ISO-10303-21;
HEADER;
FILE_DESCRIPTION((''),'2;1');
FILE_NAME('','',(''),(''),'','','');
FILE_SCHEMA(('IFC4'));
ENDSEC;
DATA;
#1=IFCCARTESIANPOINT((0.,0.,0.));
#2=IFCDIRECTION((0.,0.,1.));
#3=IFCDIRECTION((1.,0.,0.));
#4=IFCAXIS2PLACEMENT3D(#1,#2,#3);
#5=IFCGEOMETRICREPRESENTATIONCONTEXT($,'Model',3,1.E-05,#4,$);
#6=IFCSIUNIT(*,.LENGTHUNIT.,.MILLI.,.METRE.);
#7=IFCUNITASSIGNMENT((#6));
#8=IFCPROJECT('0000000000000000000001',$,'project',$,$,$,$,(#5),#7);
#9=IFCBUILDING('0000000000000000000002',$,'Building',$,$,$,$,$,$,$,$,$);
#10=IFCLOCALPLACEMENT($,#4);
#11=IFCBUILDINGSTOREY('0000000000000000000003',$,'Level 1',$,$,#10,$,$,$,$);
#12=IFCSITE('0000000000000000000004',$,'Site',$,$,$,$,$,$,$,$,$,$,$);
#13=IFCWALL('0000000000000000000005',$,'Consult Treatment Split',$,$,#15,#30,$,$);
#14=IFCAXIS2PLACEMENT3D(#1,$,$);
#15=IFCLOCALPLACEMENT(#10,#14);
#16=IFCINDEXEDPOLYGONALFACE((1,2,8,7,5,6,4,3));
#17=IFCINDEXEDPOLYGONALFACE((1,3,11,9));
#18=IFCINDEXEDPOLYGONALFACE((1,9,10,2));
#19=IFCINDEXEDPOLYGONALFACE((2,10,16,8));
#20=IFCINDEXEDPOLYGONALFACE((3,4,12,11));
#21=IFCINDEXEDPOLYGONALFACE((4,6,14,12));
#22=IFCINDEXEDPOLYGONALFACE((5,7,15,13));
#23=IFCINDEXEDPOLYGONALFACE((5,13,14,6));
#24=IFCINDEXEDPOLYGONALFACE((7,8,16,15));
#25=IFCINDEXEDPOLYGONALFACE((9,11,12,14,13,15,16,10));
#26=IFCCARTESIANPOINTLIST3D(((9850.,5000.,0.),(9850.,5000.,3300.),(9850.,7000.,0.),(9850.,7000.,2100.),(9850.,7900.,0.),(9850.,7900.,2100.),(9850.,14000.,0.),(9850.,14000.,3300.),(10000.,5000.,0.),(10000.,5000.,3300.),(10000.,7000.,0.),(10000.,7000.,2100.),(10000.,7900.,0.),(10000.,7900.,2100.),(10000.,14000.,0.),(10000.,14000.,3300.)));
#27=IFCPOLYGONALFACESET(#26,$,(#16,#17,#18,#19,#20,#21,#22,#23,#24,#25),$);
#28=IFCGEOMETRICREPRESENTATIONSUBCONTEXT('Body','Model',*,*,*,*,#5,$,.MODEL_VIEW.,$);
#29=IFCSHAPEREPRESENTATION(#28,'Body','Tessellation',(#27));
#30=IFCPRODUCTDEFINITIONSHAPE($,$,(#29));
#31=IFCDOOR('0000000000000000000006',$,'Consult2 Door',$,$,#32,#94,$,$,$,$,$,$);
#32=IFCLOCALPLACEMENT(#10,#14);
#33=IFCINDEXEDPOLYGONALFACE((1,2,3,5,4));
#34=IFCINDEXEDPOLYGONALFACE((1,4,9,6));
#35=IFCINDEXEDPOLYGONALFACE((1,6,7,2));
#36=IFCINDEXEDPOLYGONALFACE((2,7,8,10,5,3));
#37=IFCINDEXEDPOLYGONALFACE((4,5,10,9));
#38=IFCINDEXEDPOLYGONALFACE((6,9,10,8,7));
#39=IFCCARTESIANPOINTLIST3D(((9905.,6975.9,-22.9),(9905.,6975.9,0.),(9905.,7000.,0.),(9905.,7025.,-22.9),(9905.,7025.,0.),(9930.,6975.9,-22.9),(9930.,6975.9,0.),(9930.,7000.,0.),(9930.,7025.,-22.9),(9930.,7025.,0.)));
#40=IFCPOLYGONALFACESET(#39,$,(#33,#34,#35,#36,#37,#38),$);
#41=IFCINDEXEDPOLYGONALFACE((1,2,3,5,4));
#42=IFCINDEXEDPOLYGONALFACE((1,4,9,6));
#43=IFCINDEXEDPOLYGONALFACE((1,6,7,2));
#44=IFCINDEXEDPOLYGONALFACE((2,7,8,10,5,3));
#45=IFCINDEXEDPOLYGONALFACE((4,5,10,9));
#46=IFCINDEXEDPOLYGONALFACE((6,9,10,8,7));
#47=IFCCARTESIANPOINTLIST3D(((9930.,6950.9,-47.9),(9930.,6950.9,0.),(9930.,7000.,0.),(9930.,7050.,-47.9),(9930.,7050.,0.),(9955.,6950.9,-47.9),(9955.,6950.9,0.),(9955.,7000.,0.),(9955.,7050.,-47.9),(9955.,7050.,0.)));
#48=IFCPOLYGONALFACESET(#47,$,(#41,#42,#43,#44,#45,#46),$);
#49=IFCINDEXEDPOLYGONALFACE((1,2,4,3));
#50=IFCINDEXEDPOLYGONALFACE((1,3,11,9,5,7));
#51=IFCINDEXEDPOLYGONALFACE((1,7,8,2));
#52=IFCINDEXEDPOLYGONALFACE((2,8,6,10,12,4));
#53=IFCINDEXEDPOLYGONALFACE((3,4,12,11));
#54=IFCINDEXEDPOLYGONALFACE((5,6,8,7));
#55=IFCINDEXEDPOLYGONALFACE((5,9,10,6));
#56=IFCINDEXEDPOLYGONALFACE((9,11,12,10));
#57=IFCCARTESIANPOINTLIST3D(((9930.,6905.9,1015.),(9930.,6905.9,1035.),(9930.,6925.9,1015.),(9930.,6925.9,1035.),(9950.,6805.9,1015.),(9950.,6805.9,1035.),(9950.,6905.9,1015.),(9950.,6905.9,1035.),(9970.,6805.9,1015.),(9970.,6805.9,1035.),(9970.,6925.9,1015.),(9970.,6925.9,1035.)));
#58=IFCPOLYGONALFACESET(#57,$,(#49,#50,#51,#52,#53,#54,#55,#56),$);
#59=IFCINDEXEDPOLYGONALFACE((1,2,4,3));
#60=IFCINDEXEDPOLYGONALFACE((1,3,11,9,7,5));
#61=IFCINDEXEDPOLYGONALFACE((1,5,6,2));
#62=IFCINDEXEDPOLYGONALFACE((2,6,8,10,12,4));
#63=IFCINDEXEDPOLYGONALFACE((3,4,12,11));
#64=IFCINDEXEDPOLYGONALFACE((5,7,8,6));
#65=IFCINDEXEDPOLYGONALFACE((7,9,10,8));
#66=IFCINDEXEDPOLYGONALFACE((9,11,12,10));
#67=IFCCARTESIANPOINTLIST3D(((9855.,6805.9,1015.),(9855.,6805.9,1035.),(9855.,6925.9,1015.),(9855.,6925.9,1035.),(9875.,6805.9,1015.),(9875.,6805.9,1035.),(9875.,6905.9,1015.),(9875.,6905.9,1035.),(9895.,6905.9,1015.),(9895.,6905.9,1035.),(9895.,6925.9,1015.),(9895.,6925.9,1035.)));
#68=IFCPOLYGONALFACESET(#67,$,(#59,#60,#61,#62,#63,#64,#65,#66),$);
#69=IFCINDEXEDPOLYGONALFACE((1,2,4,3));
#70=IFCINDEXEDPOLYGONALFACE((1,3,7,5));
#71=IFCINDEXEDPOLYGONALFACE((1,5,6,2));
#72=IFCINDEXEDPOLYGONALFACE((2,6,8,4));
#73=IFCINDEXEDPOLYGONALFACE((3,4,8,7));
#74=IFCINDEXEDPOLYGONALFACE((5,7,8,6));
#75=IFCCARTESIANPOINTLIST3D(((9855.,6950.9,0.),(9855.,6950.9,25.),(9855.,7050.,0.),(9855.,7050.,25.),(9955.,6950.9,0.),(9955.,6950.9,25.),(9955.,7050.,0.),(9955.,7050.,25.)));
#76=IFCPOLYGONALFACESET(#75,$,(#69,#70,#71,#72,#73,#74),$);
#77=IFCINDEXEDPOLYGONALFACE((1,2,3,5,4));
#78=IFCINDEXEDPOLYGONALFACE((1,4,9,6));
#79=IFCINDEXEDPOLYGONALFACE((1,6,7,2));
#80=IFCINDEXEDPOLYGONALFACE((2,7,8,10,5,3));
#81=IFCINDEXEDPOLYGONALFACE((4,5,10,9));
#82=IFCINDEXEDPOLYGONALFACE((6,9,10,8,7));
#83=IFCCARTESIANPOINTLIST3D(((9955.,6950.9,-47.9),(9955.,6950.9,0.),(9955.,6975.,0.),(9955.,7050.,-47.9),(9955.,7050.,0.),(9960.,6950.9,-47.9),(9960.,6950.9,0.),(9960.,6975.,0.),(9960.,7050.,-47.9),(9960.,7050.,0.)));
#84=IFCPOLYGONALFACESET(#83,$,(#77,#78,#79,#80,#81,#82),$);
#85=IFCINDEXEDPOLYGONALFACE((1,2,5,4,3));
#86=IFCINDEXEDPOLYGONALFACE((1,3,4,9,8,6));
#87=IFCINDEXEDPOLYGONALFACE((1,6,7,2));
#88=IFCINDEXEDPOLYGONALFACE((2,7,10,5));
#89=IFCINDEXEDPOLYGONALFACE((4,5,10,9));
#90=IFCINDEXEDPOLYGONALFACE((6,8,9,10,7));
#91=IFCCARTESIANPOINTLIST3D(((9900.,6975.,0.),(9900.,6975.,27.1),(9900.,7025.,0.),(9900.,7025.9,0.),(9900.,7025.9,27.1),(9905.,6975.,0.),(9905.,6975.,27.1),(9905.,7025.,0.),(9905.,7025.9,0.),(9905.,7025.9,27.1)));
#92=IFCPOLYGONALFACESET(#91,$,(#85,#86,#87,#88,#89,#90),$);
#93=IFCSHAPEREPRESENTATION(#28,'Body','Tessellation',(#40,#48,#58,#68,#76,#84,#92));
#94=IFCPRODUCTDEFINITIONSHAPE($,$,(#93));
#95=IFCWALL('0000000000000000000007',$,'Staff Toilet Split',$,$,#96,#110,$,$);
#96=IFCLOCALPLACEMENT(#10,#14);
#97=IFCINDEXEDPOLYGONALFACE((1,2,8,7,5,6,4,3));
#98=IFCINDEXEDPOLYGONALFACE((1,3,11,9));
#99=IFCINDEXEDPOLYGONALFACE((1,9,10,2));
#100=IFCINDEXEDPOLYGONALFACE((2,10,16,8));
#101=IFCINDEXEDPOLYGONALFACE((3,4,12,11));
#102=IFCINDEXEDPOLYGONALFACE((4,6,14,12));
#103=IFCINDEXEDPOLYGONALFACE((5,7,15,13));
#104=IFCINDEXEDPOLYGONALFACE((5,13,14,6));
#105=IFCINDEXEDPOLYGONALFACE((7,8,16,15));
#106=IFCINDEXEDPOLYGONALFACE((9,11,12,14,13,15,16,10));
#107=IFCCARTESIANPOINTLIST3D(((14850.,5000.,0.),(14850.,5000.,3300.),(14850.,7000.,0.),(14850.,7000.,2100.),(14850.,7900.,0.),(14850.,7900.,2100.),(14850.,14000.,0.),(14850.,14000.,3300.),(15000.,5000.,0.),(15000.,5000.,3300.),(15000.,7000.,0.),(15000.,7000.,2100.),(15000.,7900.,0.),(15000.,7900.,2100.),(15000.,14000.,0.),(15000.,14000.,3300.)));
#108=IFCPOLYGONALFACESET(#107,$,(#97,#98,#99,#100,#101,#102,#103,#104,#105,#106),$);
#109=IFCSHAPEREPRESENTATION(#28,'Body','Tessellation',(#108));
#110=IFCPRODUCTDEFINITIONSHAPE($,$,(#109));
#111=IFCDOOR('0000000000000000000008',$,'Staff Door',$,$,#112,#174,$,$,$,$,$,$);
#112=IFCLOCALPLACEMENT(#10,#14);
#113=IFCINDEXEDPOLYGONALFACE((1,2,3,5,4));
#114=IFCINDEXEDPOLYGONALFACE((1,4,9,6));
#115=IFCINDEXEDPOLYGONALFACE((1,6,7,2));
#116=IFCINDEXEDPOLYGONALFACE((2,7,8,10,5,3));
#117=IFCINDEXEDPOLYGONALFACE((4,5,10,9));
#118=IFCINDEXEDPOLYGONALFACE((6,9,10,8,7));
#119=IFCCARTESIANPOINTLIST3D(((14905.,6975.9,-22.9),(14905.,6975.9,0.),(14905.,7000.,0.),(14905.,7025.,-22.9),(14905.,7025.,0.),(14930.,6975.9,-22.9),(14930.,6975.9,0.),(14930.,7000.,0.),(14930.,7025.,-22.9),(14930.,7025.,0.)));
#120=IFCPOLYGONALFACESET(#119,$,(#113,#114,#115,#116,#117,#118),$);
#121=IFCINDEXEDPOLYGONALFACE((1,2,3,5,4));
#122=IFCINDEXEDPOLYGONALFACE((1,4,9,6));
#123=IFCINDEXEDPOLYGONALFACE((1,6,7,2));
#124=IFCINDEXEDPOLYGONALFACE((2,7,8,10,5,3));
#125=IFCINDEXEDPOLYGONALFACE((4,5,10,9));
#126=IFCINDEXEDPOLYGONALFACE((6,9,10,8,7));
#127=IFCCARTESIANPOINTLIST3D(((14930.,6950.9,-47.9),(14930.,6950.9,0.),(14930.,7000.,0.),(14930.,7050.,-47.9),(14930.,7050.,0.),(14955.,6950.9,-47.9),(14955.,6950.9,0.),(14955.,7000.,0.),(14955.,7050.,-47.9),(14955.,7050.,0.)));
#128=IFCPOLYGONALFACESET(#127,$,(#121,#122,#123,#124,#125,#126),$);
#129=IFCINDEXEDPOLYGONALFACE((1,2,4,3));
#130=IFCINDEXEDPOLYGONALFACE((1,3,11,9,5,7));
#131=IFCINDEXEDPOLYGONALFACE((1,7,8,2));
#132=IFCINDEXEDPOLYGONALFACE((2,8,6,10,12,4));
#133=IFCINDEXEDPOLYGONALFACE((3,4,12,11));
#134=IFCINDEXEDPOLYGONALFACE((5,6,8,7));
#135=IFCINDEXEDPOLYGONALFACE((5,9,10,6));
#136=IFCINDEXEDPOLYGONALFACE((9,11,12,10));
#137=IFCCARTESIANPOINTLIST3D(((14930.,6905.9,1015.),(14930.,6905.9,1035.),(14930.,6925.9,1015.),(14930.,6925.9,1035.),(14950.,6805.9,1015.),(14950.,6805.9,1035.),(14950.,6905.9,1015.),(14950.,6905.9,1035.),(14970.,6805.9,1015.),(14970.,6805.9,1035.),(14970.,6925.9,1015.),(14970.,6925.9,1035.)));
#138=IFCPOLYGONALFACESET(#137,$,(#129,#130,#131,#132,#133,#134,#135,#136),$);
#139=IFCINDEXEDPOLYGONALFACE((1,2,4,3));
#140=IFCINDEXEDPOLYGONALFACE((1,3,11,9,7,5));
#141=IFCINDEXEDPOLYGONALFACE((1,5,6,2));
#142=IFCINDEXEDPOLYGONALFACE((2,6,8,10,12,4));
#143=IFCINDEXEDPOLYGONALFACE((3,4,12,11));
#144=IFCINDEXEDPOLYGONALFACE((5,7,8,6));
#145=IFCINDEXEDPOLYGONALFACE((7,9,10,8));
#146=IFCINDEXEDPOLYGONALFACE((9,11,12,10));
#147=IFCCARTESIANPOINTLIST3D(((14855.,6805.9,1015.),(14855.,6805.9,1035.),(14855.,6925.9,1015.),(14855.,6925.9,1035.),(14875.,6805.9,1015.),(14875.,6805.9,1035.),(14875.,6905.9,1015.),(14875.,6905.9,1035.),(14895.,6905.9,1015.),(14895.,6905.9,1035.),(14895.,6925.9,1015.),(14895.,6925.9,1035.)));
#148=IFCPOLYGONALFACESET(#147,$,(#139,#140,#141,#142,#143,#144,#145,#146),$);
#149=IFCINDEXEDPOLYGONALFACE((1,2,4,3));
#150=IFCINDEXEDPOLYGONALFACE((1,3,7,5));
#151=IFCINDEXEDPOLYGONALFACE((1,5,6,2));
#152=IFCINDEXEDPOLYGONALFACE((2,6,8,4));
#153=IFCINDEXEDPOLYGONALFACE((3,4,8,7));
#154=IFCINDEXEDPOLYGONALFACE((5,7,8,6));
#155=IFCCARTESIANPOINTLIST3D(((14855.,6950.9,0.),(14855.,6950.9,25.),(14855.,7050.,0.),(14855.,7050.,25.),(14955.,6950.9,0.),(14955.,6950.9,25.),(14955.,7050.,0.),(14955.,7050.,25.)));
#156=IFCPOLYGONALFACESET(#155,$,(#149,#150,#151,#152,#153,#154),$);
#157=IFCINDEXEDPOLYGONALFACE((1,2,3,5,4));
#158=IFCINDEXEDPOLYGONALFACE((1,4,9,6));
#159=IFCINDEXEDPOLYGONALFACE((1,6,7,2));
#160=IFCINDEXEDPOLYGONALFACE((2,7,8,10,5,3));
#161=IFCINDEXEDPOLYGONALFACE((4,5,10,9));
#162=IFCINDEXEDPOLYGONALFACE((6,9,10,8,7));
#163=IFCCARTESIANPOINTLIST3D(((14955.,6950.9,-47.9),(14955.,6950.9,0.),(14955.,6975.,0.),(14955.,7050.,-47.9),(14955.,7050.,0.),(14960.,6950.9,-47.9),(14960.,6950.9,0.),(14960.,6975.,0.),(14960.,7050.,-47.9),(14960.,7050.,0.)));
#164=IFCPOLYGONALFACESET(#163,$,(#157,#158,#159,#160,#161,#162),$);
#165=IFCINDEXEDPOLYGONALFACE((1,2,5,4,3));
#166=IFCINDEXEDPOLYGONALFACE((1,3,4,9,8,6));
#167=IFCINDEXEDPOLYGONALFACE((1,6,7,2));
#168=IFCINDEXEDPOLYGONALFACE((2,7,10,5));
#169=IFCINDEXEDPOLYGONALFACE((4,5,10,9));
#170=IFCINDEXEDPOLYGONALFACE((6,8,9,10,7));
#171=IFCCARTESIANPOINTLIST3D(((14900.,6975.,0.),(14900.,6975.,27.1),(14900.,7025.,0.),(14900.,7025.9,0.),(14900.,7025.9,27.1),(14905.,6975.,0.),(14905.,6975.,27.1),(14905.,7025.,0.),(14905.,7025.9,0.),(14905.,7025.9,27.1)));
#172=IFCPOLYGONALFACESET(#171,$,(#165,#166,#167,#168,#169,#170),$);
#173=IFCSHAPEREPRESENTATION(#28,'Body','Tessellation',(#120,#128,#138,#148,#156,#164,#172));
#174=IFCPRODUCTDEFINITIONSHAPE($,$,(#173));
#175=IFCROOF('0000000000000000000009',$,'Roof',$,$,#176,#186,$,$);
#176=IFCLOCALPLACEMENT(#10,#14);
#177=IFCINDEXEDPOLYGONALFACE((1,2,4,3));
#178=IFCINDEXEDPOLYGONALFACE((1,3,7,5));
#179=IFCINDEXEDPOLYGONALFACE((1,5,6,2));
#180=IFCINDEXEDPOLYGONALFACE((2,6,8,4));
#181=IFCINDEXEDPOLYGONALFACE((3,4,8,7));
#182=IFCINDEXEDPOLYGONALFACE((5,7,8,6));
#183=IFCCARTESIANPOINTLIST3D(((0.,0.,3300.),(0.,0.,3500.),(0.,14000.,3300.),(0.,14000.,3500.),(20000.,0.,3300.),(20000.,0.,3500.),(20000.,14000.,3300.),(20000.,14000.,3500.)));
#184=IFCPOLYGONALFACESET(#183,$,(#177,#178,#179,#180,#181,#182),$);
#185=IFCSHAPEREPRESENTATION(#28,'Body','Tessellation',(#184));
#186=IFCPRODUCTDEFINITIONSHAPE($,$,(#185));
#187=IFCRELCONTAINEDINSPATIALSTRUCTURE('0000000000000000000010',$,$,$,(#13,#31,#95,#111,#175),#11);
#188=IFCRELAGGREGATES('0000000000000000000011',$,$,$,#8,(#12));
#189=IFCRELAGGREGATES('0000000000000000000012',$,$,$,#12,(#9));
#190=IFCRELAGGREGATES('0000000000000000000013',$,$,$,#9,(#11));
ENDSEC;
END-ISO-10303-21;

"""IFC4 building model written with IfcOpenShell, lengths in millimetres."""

from ifc_helpers import new_model, si_unit, frame, origin_with_axes, place, context, subcontext, project, spatial, line, indexed_curve, outline, extrude, element, fill, save


model = new_model("IFC4")

# Units and contexts
model_context = context("Model", 3, precision=1e-05, world=origin_with_axes())
body_context = subcontext(model_context, "Body", "Model", "MODEL_VIEW")
ifc_project = project(units=[si_unit("LENGTHUNIT", "METRE", prefix="MILLI")], contexts=[model_context])

# Site, building, storey
site = spatial("IfcSite", under=ifc_project, Name="Site")
building = spatial("IfcBuilding", under=site, Name="Building")
storey_placement = place(None, origin_with_axes())
storey = spatial("IfcBuildingStorey", under=building, at=storey_placement, Name="Level 1")

# Walls, openings, doors
wall_1_placement = place(storey_placement, frame((10000.0, 5000.0, 0.0), z_axis=(0.0, 0.0, 1.0), x_axis=(0.0, 1.0, 0.0)))
wall_1 = element("IfcWall", 1, at=wall_1_placement, inside=storey, Name="Consult Treatment Split", context=body_context, shape_type="SweptSolid", body=[
    extrude(outline(indexed_curve([(0.0, 0.0), (0.0, 150.0), (9000.0, 150.0), (9000.0, 0.0), (0.0, 0.0)], self_intersect=False)), origin_with_axes(), (0.0, 0.0, 1.0), 3300.0),
])
opening_1_placement = place(wall_1_placement, frame((2000.0, -100.0, 0.0), z_axis=(0.0, 0.0, 1.0), x_axis=(1.0, 0.0, 0.0)))
opening_1 = element("IfcOpeningElement", 2, at=opening_1_placement, cuts=wall_1, context=body_context, shape_type="SweptSolid", body=[
    extrude(outline(indexed_curve([(0.0, 0.0), (0.0, 350.0), (900.0, 350.0), (900.0, 0.0), (0.0, 0.0)], self_intersect=False)), origin_with_axes(), (0.0, 0.0, 1.0), 2100.0),
])
door_1_placement = place(opening_1_placement, frame((0.0, 145.0, 0.0), z_axis=(0.0, 0.0, 1.0), x_axis=(1.0, 0.0, 0.0)))
door_1 = element("IfcDoor", 3, at=door_1_placement, inside=storey, Name="Consult2 Door", context=body_context, shape_type="SweptSolid", body=[
    extrude(outline(indexed_curve([(0.0, 0.0), (0.0, 2.1), (0.9, 2.1), (0.9, 0.0), (-24.1, 0.0), (-24.1, -22.9), (25.0, -22.9), (25.0, 0.0)], segments=[line(1, 2, 3, 4, 5, 6, 7, 8, 1)])), frame((0.0, 25.0, 0.0), z_axis=(0.0, -1.0, 0.0), x_axis=(1.0, 0.0, 0.0)), (0.0, 0.0, -1.0), 25.0),
    extrude(outline(indexed_curve([(0.0, 0.0), (0.0, 2.1), (0.9, 2.1), (0.9, 0.0), (-49.1, 0.0), (-49.1, -47.9), (50.0, -47.9), (50.0, 0.0)], segments=[line(1, 2, 3, 4, 5, 6, 7, 8, 1)])), frame((0.0, 0.0, 0.0), z_axis=(0.0, -1.0, 0.0), x_axis=(1.0, 0.0, 0.0)), (0.0, 0.0, -1.0), 25.0),
    extrude(outline(indexed_curve([(0.0, 0.0), (-49.1, 0.0), (-49.1, 35.0), (0.0, 35.0)], segments=[line(1, 2, 3, 4, 1)])), frame((25.0, 25.0, 25.0), z_axis=(0.0, 0.0, 1.0), x_axis=(1.0, 0.0, 0.0)), (0.0, 0.0, 1.0), -47.9),
    extrude(outline(indexed_curve([(0.0, 0.0), (0.0, -40.0), (-120.0, -40.0), (-120.0, -20.0), (-20.0, -20.0), (-20.0, 0.0)], segments=[line(1, 2, 3, 4, 5, 6, 1)])), frame((-74.1, 25.0, 1015.0), z_axis=(0.0, 0.0, 1.0), x_axis=(1.0, 0.0, 0.0)), (0.0, 0.0, 1.0), 20.0),
    extrude(outline(indexed_curve([(0.0, 0.0), (0.0, 40.0), (-120.0, 40.0), (-120.0, 20.0), (-20.0, 20.0), (-20.0, 0.0)], segments=[line(1, 2, 3, 4, 5, 6, 1)])), frame((-74.1, 60.0, 1015.0), z_axis=(0.0, 0.0, 1.0), x_axis=(1.0, 0.0, 0.0)), (0.0, 0.0, 1.0), 20.0),
    extrude(outline(indexed_curve([(0.0, 0.0), (-99.1, 0.0), (-99.1, 100.0), (0.0, 100.0)], segments=[line(1, 2, 3, 4, 1)])), frame((50.0, 0.0, 0.0), z_axis=(0.0, 0.0, 1.0), x_axis=(1.0, 0.0, 0.0)), (0.0, 0.0, 1.0), 25.0),
    extrude(outline(indexed_curve([(0.0, 0.0), (0.0, 27.1), (50.9, 27.1), (50.9, 0.0), (-24.1, 0.0), (-24.1, -47.9), (75.0, -47.9), (75.0, 0.0)], segments=[line(1, 2, 3, 4, 5, 6, 7, 8, 1)])), frame((-25.0, -5.0, 0.0), z_axis=(0.0, -1.0, 0.0), x_axis=(1.0, 0.0, 0.0)), (0.0, 0.0, -1.0), 5.0),
    extrude(outline(indexed_curve([(0.0, 0.0), (0.0, 27.1), (50.9, 27.1), (50.9, 0.0), (0.9, 0.0), (0.9, -22.9), (50.0, -22.9), (50.0, 0.0)], segments=[line(1, 2, 3, 4, 5, 6, 7, 8, 1)])), frame((-25.0, 50.0, 0.0), z_axis=(0.0, -1.0, 0.0), x_axis=(1.0, 0.0, 0.0)), (0.0, 0.0, -1.0), 5.0),
])
fill(opening_1, door_1)
wall_2_placement = place(storey_placement, frame((15000.0, 5000.0, 0.0), z_axis=(0.0, 0.0, 1.0), x_axis=(0.0, 1.0, 0.0)))
wall_2 = element("IfcWall", 4, at=wall_2_placement, inside=storey, Name="Staff Toilet Split", context=body_context, shape_type="SweptSolid", body=[
    extrude(outline(indexed_curve([(0.0, 0.0), (0.0, 150.0), (9000.0, 150.0), (9000.0, 0.0), (0.0, 0.0)], self_intersect=False)), origin_with_axes(), (0.0, 0.0, 1.0), 3300.0),
])
opening_2_placement = place(wall_2_placement, frame((2000.0, -100.0, 0.0), z_axis=(0.0, 0.0, 1.0), x_axis=(1.0, 0.0, 0.0)))
opening_2 = element("IfcOpeningElement", 5, at=opening_2_placement, cuts=wall_2, context=body_context, shape_type="SweptSolid", body=[
    extrude(outline(indexed_curve([(0.0, 0.0), (0.0, 350.0), (900.0, 350.0), (900.0, 0.0), (0.0, 0.0)], self_intersect=False)), origin_with_axes(), (0.0, 0.0, 1.0), 2100.0),
])
door_2_placement = place(opening_2_placement, frame((0.0, 145.0, 0.0), z_axis=(0.0, 0.0, 1.0), x_axis=(1.0, 0.0, 0.0)))
door_2 = element("IfcDoor", 6, at=door_2_placement, inside=storey, Name="Staff Door", context=body_context, shape_type="SweptSolid", body=[
    extrude(outline(indexed_curve([(0.0, 0.0), (0.0, 2.1), (0.9, 2.1), (0.9, 0.0), (-24.1, 0.0), (-24.1, -22.9), (25.0, -22.9), (25.0, 0.0)], segments=[line(1, 2, 3, 4, 5, 6, 7, 8, 1)])), frame((0.0, 25.0, 0.0), z_axis=(0.0, -1.0, 0.0), x_axis=(1.0, 0.0, 0.0)), (0.0, 0.0, -1.0), 25.0),
    extrude(outline(indexed_curve([(0.0, 0.0), (0.0, 2.1), (0.9, 2.1), (0.9, 0.0), (-49.1, 0.0), (-49.1, -47.9), (50.0, -47.9), (50.0, 0.0)], segments=[line(1, 2, 3, 4, 5, 6, 7, 8, 1)])), frame((0.0, 0.0, 0.0), z_axis=(0.0, -1.0, 0.0), x_axis=(1.0, 0.0, 0.0)), (0.0, 0.0, -1.0), 25.0),
    extrude(outline(indexed_curve([(0.0, 0.0), (-49.1, 0.0), (-49.1, 35.0), (0.0, 35.0)], segments=[line(1, 2, 3, 4, 1)])), frame((25.0, 25.0, 25.0), z_axis=(0.0, 0.0, 1.0), x_axis=(1.0, 0.0, 0.0)), (0.0, 0.0, 1.0), -47.9),
    extrude(outline(indexed_curve([(0.0, 0.0), (0.0, -40.0), (-120.0, -40.0), (-120.0, -20.0), (-20.0, -20.0), (-20.0, 0.0)], segments=[line(1, 2, 3, 4, 5, 6, 1)])), frame((-74.1, 25.0, 1015.0), z_axis=(0.0, 0.0, 1.0), x_axis=(1.0, 0.0, 0.0)), (0.0, 0.0, 1.0), 20.0),
    extrude(outline(indexed_curve([(0.0, 0.0), (0.0, 40.0), (-120.0, 40.0), (-120.0, 20.0), (-20.0, 20.0), (-20.0, 0.0)], segments=[line(1, 2, 3, 4, 5, 6, 1)])), frame((-74.1, 60.0, 1015.0), z_axis=(0.0, 0.0, 1.0), x_axis=(1.0, 0.0, 0.0)), (0.0, 0.0, 1.0), 20.0),
    extrude(outline(indexed_curve([(0.0, 0.0), (-99.1, 0.0), (-99.1, 100.0), (0.0, 100.0)], segments=[line(1, 2, 3, 4, 1)])), frame((50.0, 0.0, 0.0), z_axis=(0.0, 0.0, 1.0), x_axis=(1.0, 0.0, 0.0)), (0.0, 0.0, 1.0), 25.0),
    extrude(outline(indexed_curve([(0.0, 0.0), (0.0, 27.1), (50.9, 27.1), (50.9, 0.0), (-24.1, 0.0), (-24.1, -47.9), (75.0, -47.9), (75.0, 0.0)], segments=[line(1, 2, 3, 4, 5, 6, 7, 8, 1)])), frame((-25.0, -5.0, 0.0), z_axis=(0.0, -1.0, 0.0), x_axis=(1.0, 0.0, 0.0)), (0.0, 0.0, -1.0), 5.0),
    extrude(outline(indexed_curve([(0.0, 0.0), (0.0, 27.1), (50.9, 27.1), (50.9, 0.0), (0.9, 0.0), (0.9, -22.9), (50.0, -22.9), (50.0, 0.0)], segments=[line(1, 2, 3, 4, 5, 6, 7, 8, 1)])), frame((-25.0, 50.0, 0.0), z_axis=(0.0, -1.0, 0.0), x_axis=(1.0, 0.0, 0.0)), (0.0, 0.0, -1.0), 5.0),
])
fill(opening_2, door_2)

# Roof
roof_placement = place(storey_placement, frame((0.0, 0.0, 3300.0), z_axis=(0.0, 0.0, 1.0), x_axis=(1.0, 0.0, 0.0)))
element("IfcRoof", 7, at=roof_placement, inside=storey, Name="Roof", context=body_context, shape_type="SweptSolid", body=[
    extrude(outline(indexed_curve([(0.0, 0.0), (20000.0, 0.0), (20000.0, 14000.0), (0.0, 14000.0), (0.0, 0.0)])), None, (0.0, 0.0, 1.0), 200.0),
])

save(model, "model.ifc")
